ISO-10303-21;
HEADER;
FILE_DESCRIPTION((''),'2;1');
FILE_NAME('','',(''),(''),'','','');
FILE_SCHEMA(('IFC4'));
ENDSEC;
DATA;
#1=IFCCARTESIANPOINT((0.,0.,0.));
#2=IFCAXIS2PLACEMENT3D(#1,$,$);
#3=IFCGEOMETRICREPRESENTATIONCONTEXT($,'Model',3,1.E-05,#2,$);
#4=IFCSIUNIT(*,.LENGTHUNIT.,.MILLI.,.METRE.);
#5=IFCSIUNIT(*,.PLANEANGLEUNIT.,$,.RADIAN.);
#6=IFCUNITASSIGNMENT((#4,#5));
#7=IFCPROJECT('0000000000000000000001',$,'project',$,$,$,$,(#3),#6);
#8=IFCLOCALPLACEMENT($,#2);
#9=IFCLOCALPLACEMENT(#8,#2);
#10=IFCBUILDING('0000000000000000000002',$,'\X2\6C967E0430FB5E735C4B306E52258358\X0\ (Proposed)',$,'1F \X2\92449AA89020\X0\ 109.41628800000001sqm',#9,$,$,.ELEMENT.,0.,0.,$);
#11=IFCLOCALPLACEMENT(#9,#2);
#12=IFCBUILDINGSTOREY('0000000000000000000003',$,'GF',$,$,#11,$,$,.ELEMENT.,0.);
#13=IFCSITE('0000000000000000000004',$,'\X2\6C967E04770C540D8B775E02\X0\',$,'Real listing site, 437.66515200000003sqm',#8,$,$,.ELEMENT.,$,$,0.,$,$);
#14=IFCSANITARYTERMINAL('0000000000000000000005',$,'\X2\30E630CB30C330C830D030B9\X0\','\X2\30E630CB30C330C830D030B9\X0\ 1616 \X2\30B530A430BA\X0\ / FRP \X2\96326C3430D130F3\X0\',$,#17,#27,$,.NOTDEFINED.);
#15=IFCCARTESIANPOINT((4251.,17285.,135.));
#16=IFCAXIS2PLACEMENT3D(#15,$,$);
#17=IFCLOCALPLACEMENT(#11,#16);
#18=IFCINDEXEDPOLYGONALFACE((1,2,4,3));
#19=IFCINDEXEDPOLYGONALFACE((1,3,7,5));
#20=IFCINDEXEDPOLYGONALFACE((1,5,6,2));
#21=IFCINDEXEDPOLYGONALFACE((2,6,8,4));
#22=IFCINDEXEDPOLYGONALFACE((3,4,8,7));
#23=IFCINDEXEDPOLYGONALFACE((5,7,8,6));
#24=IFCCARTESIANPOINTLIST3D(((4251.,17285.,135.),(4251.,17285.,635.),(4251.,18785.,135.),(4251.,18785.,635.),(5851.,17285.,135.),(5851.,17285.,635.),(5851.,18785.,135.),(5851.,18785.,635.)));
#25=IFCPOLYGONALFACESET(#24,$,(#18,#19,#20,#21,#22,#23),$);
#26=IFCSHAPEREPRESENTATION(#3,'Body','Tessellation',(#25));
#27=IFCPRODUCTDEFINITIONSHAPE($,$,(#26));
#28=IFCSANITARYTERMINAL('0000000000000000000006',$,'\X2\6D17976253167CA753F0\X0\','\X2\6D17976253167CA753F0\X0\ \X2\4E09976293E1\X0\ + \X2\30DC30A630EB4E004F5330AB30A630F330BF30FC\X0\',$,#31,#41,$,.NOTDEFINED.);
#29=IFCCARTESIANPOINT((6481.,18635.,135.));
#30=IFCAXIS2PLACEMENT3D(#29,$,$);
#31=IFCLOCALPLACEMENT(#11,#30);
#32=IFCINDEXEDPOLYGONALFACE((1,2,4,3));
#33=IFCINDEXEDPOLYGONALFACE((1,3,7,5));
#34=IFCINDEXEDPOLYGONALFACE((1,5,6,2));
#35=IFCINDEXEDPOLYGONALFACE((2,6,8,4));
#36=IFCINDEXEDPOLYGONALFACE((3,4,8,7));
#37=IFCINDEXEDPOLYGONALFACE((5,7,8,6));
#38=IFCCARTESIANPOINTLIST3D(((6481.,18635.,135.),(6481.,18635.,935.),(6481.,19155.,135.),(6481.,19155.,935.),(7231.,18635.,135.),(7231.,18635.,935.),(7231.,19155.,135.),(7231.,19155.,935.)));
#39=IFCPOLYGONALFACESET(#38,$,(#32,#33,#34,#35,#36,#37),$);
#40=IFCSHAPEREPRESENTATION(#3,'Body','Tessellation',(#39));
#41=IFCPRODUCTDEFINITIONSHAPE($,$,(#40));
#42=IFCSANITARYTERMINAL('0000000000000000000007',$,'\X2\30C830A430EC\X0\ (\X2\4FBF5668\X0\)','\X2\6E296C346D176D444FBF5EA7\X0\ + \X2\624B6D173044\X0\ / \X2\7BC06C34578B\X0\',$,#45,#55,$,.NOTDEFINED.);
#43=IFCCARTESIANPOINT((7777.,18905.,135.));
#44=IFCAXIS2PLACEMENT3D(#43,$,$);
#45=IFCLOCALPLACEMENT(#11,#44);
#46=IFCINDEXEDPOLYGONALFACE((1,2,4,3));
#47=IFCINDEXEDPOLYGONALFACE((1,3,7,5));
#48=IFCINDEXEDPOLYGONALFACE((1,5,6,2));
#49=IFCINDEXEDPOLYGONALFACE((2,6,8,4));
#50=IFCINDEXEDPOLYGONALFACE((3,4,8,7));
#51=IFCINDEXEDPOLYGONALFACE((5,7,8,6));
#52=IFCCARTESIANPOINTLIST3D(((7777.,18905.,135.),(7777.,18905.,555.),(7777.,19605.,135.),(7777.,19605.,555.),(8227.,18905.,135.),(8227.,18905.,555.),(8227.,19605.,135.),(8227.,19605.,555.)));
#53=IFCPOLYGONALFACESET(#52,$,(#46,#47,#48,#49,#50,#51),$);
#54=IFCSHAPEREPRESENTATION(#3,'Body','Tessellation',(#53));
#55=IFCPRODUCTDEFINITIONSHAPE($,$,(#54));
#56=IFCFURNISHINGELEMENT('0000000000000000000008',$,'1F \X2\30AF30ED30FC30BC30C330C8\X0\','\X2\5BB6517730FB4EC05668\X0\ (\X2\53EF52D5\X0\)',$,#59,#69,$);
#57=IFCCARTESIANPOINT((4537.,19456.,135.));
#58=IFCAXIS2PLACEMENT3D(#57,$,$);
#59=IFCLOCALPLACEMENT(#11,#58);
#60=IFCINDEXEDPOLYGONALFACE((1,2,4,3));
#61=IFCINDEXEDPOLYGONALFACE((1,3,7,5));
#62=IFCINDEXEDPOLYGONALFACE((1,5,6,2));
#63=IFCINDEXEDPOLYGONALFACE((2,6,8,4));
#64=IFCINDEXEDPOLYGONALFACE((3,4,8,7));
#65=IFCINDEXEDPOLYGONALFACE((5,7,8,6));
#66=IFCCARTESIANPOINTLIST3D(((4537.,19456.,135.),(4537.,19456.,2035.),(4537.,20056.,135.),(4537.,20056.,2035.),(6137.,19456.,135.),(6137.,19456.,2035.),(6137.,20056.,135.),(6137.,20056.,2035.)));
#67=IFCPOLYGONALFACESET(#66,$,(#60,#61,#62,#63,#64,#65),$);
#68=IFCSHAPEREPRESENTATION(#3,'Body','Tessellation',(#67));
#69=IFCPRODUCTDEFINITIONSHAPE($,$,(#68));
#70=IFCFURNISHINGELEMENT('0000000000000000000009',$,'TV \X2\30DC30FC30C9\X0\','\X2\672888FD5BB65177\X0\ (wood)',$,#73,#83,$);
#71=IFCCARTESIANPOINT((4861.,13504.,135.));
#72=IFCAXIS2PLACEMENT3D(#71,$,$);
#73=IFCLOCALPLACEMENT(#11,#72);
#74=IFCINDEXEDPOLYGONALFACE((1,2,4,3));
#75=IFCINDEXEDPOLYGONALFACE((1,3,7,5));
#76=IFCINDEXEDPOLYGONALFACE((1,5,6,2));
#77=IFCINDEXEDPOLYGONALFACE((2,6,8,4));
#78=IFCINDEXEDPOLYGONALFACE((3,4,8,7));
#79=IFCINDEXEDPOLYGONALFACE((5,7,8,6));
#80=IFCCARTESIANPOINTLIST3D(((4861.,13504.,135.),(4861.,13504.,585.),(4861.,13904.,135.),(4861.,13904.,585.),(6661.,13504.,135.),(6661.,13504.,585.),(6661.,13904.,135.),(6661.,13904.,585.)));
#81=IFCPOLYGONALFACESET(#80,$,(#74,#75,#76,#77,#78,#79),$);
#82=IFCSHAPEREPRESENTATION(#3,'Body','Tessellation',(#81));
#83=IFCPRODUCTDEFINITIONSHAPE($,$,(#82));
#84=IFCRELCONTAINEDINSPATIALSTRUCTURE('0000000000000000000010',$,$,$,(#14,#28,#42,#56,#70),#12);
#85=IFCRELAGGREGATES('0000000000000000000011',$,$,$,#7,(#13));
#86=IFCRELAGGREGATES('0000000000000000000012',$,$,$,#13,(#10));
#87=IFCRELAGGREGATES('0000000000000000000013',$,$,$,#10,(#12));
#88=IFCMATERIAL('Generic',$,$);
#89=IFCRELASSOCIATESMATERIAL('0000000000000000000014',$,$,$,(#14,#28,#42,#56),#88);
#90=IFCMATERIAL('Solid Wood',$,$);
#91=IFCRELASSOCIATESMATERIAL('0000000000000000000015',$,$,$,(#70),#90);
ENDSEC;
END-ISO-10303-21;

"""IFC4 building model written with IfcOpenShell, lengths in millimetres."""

from ifc_helpers import new_model, si_unit, frame, frame_2d, origin, place, context, project, spatial, rectangle, extrude, material, element, save


model = new_model("IFC4")

# Units and contexts
model_context = context("Model", 3, precision=1e-05, world=origin())
ifc_project = project(units=[si_unit("LENGTHUNIT", "METRE", prefix="MILLI"), si_unit("PLANEANGLEUNIT", "RADIAN")], contexts=[model_context])

# Site, building, storey
site_placement = place(None, origin())
site = spatial("IfcSite", under=ifc_project, at=site_placement, Name="沖縄県名護市", ObjectType="Real listing site, 437.66515200000003sqm", CompositionType="ELEMENT", RefElevation=0.0)
building_placement = place(site_placement, origin())
building = spatial("IfcBuilding", under=site, at=building_placement, Name="沖縄・平屋の別荘 (Proposed)", ObjectType="1F 鉄骨造 109.41628800000001sqm", CompositionType="ELEMENT", ElevationOfRefHeight=0.0, ElevationOfTerrain=0.0)
storey_placement = place(building_placement, origin())
storey = spatial("IfcBuildingStorey", under=building, at=storey_placement, Name="GF", CompositionType="ELEMENT", Elevation=0.0)

# Shared definitions
ifc_material_1 = material(Name="Solid Wood")

# Shared definitions
ifc_material_2 = material(Name="Generic")

# Sanitary terminals
sanitary_terminal_1_placement = place(storey_placement, frame((4251.0, 17285.0, 135.0)))
element("IfcSanitaryTerminal", 1, at=sanitary_terminal_1_placement, inside=storey, material=ifc_material_2, Name="ユニットバス", Description="ユニットバス 1616 サイズ / FRP 防水パン", PredefinedType="NOTDEFINED", context=model_context, shape_type="SweptSolid", body=[
    extrude(rectangle(XDim=1600.0, YDim=1500.0, at=frame_2d((800.0, 750.0))), frame((4251.0, 17285.0, 135.0)), (0.0, 0.0, 1.0), 500.0),
])
sanitary_terminal_2_placement = place(storey_placement, frame((6481.0, 18635.0, 135.0)))
element("IfcSanitaryTerminal", 2, at=sanitary_terminal_2_placement, inside=storey, material=ifc_material_2, Name="洗面化粧台", Description="洗面化粧台 三面鏡 + ボウル一体カウンター", PredefinedType="NOTDEFINED", context=model_context, shape_type="SweptSolid", body=[
    extrude(rectangle(XDim=750.0, YDim=520.0, at=frame_2d((375.0, 260.0))), frame((6481.0, 18635.0, 135.0)), (0.0, 0.0, 1.0), 800.0),
])
sanitary_terminal_3_placement = place(storey_placement, frame((7777.0, 18905.0, 135.0)))
element("IfcSanitaryTerminal", 3, at=sanitary_terminal_3_placement, inside=storey, material=ifc_material_2, Name="トイレ (便器)", Description="温水洗浄便座 + 手洗い / 節水型", PredefinedType="NOTDEFINED", context=model_context, shape_type="SweptSolid", body=[
    extrude(rectangle(XDim=450.0, YDim=700.0, at=frame_2d((225.0, 350.0))), frame((7777.0, 18905.0, 135.0)), (0.0, 0.0, 1.0), 420.0),
])

# Furnishing elements
furnishing_1_placement = place(storey_placement, frame((4537.0, 19456.0, 135.0)))
element("IfcFurnishingElement", 4, at=furnishing_1_placement, inside=storey, material=ifc_material_2, Name="1F クローゼット", Description="家具・什器 (可動)", context=model_context, shape_type="SweptSolid", body=[
    extrude(rectangle(XDim=1600.0, YDim=600.0, at=frame_2d((800.0, 300.0))), frame((4537.0, 19456.0, 135.0)), (0.0, 0.0, 1.0), 1900.0),
])
furnishing_2_placement = place(storey_placement, frame((4861.0, 13504.0, 135.0)))
element("IfcFurnishingElement", 5, at=furnishing_2_placement, inside=storey, material=ifc_material_1, Name="TV ボード", Description="木製家具 (wood)", context=model_context, shape_type="SweptSolid", body=[
    extrude(rectangle(XDim=1800.0, YDim=400.0, at=frame_2d((900.0, 200.0))), frame((4861.0, 13504.0, 135.0)), (0.0, 0.0, 1.0), 450.0),
])

save(model, "model.ifc")
